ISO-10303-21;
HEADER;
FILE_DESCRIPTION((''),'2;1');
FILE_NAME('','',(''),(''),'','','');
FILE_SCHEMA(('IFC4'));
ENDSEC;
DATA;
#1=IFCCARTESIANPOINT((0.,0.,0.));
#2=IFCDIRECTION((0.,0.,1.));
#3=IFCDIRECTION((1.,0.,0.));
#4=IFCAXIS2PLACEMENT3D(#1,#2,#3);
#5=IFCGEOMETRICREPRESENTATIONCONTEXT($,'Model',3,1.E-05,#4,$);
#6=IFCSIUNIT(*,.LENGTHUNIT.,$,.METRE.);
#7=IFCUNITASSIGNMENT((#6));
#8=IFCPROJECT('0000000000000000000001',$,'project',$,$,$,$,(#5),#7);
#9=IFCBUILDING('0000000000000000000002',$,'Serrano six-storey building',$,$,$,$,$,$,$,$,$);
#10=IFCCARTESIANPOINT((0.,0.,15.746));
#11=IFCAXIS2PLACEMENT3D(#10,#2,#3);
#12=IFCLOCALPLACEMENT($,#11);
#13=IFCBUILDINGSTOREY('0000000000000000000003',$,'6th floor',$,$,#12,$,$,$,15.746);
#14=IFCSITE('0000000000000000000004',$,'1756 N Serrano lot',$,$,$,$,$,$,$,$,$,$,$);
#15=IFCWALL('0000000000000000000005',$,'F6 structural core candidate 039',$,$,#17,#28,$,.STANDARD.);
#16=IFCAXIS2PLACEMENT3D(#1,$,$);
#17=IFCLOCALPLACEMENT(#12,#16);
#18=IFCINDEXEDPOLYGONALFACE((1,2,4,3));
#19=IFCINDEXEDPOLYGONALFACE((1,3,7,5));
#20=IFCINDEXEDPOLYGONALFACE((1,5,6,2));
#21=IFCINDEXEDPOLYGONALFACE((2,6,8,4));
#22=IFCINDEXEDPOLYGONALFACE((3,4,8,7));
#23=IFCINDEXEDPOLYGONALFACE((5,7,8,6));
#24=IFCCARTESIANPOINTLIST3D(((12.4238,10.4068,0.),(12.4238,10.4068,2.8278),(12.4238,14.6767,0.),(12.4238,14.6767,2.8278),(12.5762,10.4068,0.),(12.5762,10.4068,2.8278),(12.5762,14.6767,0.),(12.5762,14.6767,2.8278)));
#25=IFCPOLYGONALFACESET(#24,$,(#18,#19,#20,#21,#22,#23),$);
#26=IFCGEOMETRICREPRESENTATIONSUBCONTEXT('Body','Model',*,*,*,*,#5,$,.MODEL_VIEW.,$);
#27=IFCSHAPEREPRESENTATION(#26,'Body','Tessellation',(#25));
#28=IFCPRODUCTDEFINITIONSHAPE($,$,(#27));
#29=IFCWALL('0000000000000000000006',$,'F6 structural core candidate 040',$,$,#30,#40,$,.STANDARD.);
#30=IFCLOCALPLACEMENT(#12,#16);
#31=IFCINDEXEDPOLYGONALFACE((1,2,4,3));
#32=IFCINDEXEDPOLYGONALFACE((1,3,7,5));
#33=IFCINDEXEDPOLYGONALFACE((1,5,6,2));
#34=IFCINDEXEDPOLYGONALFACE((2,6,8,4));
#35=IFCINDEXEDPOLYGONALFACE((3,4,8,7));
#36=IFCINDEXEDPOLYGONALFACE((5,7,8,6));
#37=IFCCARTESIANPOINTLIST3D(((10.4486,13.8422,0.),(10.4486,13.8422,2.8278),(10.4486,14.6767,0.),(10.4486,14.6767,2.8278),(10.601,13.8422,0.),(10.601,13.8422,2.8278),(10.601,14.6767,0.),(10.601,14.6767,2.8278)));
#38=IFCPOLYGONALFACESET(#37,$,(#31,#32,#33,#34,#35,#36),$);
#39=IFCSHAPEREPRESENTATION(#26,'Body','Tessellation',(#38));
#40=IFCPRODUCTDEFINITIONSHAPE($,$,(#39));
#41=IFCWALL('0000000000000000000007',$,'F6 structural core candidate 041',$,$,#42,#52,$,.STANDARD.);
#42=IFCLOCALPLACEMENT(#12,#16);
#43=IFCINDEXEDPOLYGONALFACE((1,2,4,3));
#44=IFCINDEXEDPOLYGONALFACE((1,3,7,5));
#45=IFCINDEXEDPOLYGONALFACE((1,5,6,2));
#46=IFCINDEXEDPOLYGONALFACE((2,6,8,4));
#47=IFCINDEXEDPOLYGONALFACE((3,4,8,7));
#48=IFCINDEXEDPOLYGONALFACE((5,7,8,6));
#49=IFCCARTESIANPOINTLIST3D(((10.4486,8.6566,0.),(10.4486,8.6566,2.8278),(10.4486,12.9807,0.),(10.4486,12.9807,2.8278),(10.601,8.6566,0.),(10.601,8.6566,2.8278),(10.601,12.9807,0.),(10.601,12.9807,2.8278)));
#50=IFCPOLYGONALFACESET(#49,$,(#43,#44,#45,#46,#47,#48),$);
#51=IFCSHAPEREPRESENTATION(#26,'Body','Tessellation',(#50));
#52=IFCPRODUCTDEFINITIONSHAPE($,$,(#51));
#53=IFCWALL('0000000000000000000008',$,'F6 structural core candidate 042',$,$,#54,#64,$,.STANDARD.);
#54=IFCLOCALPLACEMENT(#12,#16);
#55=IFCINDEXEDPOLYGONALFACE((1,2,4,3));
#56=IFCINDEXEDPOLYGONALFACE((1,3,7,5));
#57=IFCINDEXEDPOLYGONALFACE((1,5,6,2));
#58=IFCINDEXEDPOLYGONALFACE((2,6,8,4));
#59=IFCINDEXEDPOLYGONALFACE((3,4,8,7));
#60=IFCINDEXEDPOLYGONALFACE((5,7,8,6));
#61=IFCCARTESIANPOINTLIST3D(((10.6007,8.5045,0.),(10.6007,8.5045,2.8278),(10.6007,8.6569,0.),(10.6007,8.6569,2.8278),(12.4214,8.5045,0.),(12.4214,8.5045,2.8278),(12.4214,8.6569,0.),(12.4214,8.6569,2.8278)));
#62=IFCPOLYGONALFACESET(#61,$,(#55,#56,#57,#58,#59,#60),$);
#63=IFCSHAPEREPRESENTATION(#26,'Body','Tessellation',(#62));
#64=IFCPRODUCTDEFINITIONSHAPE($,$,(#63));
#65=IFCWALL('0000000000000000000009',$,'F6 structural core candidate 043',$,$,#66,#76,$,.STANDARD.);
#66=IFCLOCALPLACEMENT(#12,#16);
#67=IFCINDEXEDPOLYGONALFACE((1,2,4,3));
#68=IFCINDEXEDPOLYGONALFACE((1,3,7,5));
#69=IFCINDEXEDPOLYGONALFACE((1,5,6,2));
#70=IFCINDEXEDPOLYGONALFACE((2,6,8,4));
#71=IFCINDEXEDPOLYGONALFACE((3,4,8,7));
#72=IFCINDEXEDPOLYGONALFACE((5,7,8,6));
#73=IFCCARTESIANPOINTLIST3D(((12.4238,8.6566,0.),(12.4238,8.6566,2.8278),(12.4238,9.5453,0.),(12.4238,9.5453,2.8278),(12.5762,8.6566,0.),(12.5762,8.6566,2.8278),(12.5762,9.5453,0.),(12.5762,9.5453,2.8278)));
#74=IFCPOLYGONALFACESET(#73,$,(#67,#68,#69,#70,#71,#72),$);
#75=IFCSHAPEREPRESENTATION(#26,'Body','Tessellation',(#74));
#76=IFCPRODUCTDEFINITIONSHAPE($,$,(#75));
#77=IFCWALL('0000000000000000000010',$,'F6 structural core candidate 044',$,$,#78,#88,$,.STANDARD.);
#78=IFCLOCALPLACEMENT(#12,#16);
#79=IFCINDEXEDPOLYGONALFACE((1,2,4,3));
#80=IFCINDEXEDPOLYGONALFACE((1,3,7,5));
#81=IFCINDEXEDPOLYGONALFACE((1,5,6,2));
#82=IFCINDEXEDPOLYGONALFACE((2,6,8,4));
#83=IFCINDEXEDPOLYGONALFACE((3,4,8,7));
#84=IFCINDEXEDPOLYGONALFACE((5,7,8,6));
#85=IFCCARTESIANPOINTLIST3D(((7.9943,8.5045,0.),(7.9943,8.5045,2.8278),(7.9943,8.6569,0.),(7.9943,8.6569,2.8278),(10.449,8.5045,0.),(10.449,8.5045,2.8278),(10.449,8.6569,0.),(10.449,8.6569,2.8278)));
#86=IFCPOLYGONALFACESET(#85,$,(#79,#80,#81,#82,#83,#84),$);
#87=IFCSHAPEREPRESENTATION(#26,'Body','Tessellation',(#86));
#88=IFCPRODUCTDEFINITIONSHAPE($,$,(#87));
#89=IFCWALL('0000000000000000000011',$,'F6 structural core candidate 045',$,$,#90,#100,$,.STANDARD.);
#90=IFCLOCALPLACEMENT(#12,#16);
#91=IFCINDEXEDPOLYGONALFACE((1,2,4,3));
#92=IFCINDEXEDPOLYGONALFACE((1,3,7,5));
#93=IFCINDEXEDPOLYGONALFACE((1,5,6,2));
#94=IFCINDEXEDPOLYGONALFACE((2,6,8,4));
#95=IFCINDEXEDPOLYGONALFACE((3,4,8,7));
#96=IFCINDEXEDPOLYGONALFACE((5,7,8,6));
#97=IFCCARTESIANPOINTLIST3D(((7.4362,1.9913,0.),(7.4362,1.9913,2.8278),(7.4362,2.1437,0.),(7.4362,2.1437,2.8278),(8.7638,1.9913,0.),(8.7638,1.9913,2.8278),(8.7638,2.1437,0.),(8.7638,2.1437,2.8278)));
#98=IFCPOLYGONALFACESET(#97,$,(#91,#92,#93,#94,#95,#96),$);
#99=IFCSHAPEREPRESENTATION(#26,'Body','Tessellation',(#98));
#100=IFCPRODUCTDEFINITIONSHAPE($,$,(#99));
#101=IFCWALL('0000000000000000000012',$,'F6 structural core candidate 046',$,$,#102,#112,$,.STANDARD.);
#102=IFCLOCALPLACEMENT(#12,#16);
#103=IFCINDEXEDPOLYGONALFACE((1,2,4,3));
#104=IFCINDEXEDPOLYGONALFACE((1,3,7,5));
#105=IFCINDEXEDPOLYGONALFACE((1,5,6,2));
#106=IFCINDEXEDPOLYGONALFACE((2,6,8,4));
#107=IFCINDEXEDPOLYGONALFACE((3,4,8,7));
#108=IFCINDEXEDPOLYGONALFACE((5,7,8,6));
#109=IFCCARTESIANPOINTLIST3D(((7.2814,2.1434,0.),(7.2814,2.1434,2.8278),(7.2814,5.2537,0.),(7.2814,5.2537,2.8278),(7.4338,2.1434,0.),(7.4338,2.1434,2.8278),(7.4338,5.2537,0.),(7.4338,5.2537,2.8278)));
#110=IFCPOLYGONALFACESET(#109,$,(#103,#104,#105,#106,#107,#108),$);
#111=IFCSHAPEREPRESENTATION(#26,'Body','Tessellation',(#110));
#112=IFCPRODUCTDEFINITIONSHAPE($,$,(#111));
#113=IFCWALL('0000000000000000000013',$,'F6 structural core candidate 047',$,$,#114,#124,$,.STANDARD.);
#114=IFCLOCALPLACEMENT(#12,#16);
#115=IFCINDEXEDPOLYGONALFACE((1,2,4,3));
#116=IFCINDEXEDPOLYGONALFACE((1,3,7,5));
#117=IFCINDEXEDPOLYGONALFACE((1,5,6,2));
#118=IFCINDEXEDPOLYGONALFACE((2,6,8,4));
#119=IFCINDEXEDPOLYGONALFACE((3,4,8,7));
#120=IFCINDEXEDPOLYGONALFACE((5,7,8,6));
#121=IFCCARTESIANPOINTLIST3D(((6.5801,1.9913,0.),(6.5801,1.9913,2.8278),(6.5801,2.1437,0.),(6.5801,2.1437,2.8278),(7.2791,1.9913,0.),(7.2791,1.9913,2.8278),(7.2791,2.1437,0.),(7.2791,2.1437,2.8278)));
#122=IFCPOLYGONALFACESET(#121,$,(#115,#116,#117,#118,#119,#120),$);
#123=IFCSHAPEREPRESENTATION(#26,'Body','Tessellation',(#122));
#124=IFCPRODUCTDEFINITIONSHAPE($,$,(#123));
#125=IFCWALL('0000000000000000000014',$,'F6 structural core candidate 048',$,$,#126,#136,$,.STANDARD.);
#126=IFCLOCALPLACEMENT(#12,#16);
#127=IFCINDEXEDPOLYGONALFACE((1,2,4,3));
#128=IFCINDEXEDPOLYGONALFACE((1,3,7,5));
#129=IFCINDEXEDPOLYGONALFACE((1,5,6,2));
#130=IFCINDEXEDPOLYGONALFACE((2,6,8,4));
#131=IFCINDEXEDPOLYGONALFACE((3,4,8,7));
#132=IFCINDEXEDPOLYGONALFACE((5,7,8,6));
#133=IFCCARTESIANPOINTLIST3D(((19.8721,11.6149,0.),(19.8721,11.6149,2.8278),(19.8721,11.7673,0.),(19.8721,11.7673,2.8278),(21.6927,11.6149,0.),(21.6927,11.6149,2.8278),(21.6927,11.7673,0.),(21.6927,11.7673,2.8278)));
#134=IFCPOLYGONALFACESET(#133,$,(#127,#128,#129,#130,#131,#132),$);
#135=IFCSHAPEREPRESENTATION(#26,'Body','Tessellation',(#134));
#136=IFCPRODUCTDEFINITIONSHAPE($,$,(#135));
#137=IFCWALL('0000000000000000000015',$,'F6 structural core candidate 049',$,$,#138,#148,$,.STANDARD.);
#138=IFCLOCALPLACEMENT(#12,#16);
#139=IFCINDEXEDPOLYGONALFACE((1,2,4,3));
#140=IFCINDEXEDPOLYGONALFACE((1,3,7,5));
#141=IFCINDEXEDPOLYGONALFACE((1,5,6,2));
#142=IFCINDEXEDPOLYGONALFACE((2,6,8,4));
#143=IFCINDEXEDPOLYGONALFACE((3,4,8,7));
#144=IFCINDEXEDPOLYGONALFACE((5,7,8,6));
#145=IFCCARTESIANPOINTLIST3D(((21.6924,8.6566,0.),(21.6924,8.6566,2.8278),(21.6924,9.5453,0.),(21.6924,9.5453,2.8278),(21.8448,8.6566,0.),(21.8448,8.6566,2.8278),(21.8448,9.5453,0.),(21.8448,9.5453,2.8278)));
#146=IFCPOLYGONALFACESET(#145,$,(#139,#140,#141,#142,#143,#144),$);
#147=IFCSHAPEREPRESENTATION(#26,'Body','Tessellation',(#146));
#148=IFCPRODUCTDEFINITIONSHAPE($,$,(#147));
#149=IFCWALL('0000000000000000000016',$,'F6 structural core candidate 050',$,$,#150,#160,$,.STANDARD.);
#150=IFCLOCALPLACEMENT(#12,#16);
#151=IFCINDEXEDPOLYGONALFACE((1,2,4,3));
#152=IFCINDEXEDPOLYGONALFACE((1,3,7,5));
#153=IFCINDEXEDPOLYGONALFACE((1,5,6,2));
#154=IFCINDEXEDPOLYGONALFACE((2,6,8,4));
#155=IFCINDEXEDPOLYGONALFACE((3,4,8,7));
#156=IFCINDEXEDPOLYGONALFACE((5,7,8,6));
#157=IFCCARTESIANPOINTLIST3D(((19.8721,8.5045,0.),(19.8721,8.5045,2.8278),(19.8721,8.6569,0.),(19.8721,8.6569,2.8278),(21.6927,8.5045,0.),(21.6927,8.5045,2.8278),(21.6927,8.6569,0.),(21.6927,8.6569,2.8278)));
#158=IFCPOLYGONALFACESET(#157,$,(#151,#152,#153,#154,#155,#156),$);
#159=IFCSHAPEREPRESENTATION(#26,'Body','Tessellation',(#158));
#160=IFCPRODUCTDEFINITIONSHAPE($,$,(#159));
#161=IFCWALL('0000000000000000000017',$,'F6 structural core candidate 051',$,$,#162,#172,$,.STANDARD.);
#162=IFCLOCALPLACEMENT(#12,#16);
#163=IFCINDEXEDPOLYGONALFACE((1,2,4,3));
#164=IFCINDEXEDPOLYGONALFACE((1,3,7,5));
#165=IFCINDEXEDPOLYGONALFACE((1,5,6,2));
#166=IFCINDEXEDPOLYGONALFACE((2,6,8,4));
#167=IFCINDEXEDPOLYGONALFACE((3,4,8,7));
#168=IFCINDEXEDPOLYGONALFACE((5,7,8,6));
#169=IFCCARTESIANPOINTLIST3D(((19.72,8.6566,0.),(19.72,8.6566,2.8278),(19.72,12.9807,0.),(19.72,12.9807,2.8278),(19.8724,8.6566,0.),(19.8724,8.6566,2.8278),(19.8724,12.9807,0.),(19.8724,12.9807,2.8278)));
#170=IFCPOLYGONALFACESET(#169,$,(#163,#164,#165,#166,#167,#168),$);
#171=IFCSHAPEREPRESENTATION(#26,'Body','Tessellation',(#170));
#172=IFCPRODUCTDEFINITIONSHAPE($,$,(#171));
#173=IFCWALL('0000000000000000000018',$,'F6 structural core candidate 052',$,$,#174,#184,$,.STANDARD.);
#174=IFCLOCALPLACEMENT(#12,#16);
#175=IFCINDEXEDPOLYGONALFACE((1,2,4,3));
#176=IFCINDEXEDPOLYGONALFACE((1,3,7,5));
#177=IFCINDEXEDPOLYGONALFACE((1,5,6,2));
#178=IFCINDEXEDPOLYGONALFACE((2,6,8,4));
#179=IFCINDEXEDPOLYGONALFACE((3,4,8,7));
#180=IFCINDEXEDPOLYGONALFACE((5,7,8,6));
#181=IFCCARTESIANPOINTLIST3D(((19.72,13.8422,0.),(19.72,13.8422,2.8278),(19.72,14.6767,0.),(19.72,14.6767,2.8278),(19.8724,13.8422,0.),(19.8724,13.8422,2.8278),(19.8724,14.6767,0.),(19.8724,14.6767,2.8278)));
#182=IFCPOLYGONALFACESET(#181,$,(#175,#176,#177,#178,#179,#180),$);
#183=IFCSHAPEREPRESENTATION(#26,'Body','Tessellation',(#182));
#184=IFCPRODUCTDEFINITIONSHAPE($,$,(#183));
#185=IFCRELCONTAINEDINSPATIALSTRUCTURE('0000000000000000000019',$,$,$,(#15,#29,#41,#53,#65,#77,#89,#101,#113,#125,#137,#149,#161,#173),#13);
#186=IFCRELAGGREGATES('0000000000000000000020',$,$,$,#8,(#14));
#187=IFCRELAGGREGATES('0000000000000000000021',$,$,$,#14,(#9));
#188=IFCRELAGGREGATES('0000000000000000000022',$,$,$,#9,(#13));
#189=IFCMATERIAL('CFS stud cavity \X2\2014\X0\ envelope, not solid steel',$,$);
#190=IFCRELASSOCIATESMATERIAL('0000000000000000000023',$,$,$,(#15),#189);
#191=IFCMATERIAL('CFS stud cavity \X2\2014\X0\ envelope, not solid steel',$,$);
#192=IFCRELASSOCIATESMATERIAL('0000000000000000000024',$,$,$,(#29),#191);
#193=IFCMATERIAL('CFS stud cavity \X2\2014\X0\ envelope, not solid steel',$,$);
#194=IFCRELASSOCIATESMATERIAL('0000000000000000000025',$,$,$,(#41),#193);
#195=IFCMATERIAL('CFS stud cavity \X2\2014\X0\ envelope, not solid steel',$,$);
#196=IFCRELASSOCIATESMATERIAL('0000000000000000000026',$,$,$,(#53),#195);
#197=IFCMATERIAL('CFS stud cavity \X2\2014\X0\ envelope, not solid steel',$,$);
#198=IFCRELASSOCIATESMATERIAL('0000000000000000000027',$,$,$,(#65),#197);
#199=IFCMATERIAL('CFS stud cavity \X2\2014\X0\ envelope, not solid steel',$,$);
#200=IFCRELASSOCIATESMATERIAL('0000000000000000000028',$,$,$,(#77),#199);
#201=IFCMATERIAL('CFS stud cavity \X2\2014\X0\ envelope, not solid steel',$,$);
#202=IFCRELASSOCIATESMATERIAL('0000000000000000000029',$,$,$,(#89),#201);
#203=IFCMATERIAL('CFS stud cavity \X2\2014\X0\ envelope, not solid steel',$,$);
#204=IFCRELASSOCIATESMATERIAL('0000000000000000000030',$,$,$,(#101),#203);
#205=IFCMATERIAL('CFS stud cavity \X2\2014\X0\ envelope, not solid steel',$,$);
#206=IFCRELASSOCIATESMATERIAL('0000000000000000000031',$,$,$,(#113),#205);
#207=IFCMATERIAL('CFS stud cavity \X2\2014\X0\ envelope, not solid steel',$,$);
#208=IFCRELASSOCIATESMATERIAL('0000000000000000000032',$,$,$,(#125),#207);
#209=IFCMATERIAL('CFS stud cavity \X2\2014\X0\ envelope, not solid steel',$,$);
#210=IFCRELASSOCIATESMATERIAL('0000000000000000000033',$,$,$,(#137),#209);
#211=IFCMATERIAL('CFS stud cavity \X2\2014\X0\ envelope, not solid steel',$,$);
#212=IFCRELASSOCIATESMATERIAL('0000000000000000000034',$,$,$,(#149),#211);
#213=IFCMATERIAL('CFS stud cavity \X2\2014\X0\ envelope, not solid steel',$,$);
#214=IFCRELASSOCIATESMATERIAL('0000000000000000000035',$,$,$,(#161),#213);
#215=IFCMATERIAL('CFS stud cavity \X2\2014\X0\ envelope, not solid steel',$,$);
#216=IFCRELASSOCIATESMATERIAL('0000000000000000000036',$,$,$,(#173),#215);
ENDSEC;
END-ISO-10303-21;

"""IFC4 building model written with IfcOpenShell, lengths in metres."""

from ifc_helpers import new_model, si_unit, frame, origin_with_axes, place, context, subcontext, project, spatial, polyline, outline, extrude, material, element, save


model = new_model("IFC4")

# Units and contexts
model_context = context("Model", 3, precision=1e-05, world=origin_with_axes())
body_context = subcontext(model_context, "Body", "Model", "MODEL_VIEW")
ifc_project = project(units=[si_unit("LENGTHUNIT", "METRE")], contexts=[model_context])

# Site, building, storey
site = spatial("IfcSite", under=ifc_project, Name="1756 N Serrano lot")
building = spatial("IfcBuilding", under=site, Name="Serrano six-storey building")
storey_placement = place(None, frame((0.0, 0.0, 15.746), z_axis=(0.0, 0.0, 1.0), x_axis=(1.0, 0.0, 0.0)))
storey = spatial("IfcBuildingStorey", under=building, at=storey_placement, Name="6th floor", Elevation=15.746)

# Walls
ifc_material_1 = material(Name="CFS stud cavity — envelope, not solid steel")
wall_1_placement = place(storey_placement, frame((0.0, 0.0, -15.746), z_axis=(0.0, 0.0, 1.0), x_axis=(1.0, 0.0, 0.0)))
element("IfcWall", 1, at=wall_1_placement, inside=storey, material=ifc_material_1, Name="F6 structural core candidate 039", PredefinedType="STANDARD", context=body_context, shape_type="SweptSolid", body=[
    extrude(outline(polyline([(12.5762, 10.4068), (12.4238, 10.4068), (12.4238, 14.6767), (12.5762, 14.6767), (12.5762, 10.4068)])), frame((0.0, 0.0, 15.746)), (0.0, 0.0, 1.0), 2.8278),
])
ifc_material_2 = material(Name="CFS stud cavity — envelope, not solid steel")
wall_2_placement = place(storey_placement, frame((0.0, 0.0, -15.746), z_axis=(0.0, 0.0, 1.0), x_axis=(1.0, 0.0, 0.0)))
element("IfcWall", 2, at=wall_2_placement, inside=storey, material=ifc_material_2, Name="F6 structural core candidate 040", PredefinedType="STANDARD", context=body_context, shape_type="SweptSolid", body=[
    extrude(outline(polyline([(10.601, 13.8422), (10.4486, 13.8422), (10.4486, 14.6767), (10.601, 14.6767), (10.601, 13.8422)])), frame((0.0, 0.0, 15.746)), (0.0, 0.0, 1.0), 2.8278),
])
ifc_material_3 = material(Name="CFS stud cavity — envelope, not solid steel")
wall_3_placement = place(storey_placement, frame((0.0, 0.0, -15.746), z_axis=(0.0, 0.0, 1.0), x_axis=(1.0, 0.0, 0.0)))
element("IfcWall", 3, at=wall_3_placement, inside=storey, material=ifc_material_3, Name="F6 structural core candidate 041", PredefinedType="STANDARD", context=body_context, shape_type="SweptSolid", body=[
    extrude(outline(polyline([(10.601, 8.6566), (10.4486, 8.6566), (10.4486, 12.9807), (10.601, 12.9807), (10.601, 8.6566)])), frame((0.0, 0.0, 15.746)), (0.0, 0.0, 1.0), 2.8278),
])
ifc_material_4 = material(Name="CFS stud cavity — envelope, not solid steel")
wall_4_placement = place(storey_placement, frame((0.0, 0.0, -15.746), z_axis=(0.0, 0.0, 1.0), x_axis=(1.0, 0.0, 0.0)))
element("IfcWall", 4, at=wall_4_placement, inside=storey, material=ifc_material_4, Name="F6 structural core candidate 042", PredefinedType="STANDARD", context=body_context, shape_type="SweptSolid", body=[
    extrude(outline(polyline([(12.4214, 8.6569), (12.4214, 8.5045), (10.6007, 8.5045), (10.6007, 8.6569), (12.4214, 8.6569)])), frame((0.0, 0.0, 15.746)), (0.0, 0.0, 1.0), 2.8278),
])
ifc_material_5 = material(Name="CFS stud cavity — envelope, not solid steel")
wall_5_placement = place(storey_placement, frame((0.0, 0.0, -15.746), z_axis=(0.0, 0.0, 1.0), x_axis=(1.0, 0.0, 0.0)))
element("IfcWall", 5, at=wall_5_placement, inside=storey, material=ifc_material_5, Name="F6 structural core candidate 043", PredefinedType="STANDARD", context=body_context, shape_type="SweptSolid", body=[
    extrude(outline(polyline([(12.5762, 8.6566), (12.4238, 8.6566), (12.4238, 9.5453), (12.5762, 9.5453), (12.5762, 8.6566)])), frame((0.0, 0.0, 15.746)), (0.0, 0.0, 1.0), 2.8278),
])
ifc_material_6 = material(Name="CFS stud cavity — envelope, not solid steel")
wall_6_placement = place(storey_placement, frame((0.0, 0.0, -15.746), z_axis=(0.0, 0.0, 1.0), x_axis=(1.0, 0.0, 0.0)))
element("IfcWall", 6, at=wall_6_placement, inside=storey, material=ifc_material_6, Name="F6 structural core candidate 044", PredefinedType="STANDARD", context=body_context, shape_type="SweptSolid", body=[
    extrude(outline(polyline([(10.449, 8.6569), (10.449, 8.5045), (7.9943, 8.5045), (7.9943, 8.6569), (10.449, 8.6569)])), frame((0.0, 0.0, 15.746)), (0.0, 0.0, 1.0), 2.8278),
])
ifc_material_7 = material(Name="CFS stud cavity — envelope, not solid steel")
wall_7_placement = place(storey_placement, frame((0.0, 0.0, -15.746), z_axis=(0.0, 0.0, 1.0), x_axis=(1.0, 0.0, 0.0)))
element("IfcWall", 7, at=wall_7_placement, inside=storey, material=ifc_material_7, Name="F6 structural core candidate 045", PredefinedType="STANDARD", context=body_context, shape_type="SweptSolid", body=[
    extrude(outline(polyline([(8.7638, 2.1437), (8.7638, 1.9913), (7.4362, 1.9913), (7.4362, 2.1437), (8.7638, 2.1437)])), frame((0.0, 0.0, 15.746)), (0.0, 0.0, 1.0), 2.8278),
])
ifc_material_8 = material(Name="CFS stud cavity — envelope, not solid steel")
wall_8_placement = place(storey_placement, frame((0.0, 0.0, -15.746), z_axis=(0.0, 0.0, 1.0), x_axis=(1.0, 0.0, 0.0)))
element("IfcWall", 8, at=wall_8_placement, inside=storey, material=ifc_material_8, Name="F6 structural core candidate 046", PredefinedType="STANDARD", context=body_context, shape_type="SweptSolid", body=[
    extrude(outline(polyline([(7.4338, 2.1434), (7.2814, 2.1434), (7.2814, 5.2537), (7.4338, 5.2537), (7.4338, 2.1434)])), frame((0.0, 0.0, 15.746)), (0.0, 0.0, 1.0), 2.8278),
])
ifc_material_9 = material(Name="CFS stud cavity — envelope, not solid steel")
wall_9_placement = place(storey_placement, frame((0.0, 0.0, -15.746), z_axis=(0.0, 0.0, 1.0), x_axis=(1.0, 0.0, 0.0)))
element("IfcWall", 9, at=wall_9_placement, inside=storey, material=ifc_material_9, Name="F6 structural core candidate 047", PredefinedType="STANDARD", context=body_context, shape_type="SweptSolid", body=[
    extrude(outline(polyline([(7.2791, 2.1437), (7.2791, 1.9913), (6.5801, 1.9913), (6.5801, 2.1437), (7.2791, 2.1437)])), frame((0.0, 0.0, 15.746)), (0.0, 0.0, 1.0), 2.8278),
])
ifc_material_10 = material(Name="CFS stud cavity — envelope, not solid steel")
wall_10_placement = place(storey_placement, frame((0.0, 0.0, -15.746), z_axis=(0.0, 0.0, 1.0), x_axis=(1.0, 0.0, 0.0)))
element("IfcWall", 10, at=wall_10_placement, inside=storey, material=ifc_material_10, Name="F6 structural core candidate 048", PredefinedType="STANDARD", context=body_context, shape_type="SweptSolid", body=[
    extrude(outline(polyline([(21.6927, 11.7673), (21.6927, 11.6149), (19.8721, 11.6149), (19.8721, 11.7673), (21.6927, 11.7673)])), frame((0.0, 0.0, 15.746)), (0.0, 0.0, 1.0), 2.8278),
])
ifc_material_11 = material(Name="CFS stud cavity — envelope, not solid steel")
wall_11_placement = place(storey_placement, frame((0.0, 0.0, -15.746), z_axis=(0.0, 0.0, 1.0), x_axis=(1.0, 0.0, 0.0)))
element("IfcWall", 11, at=wall_11_placement, inside=storey, material=ifc_material_11, Name="F6 structural core candidate 049", PredefinedType="STANDARD", context=body_context, shape_type="SweptSolid", body=[
    extrude(outline(polyline([(21.8448, 8.6566), (21.6924, 8.6566), (21.6924, 9.5453), (21.8448, 9.5453), (21.8448, 8.6566)])), frame((0.0, 0.0, 15.746)), (0.0, 0.0, 1.0), 2.8278),
])
ifc_material_12 = material(Name="CFS stud cavity — envelope, not solid steel")
wall_12_placement = place(storey_placement, frame((0.0, 0.0, -15.746), z_axis=(0.0, 0.0, 1.0), x_axis=(1.0, 0.0, 0.0)))
element("IfcWall", 12, at=wall_12_placement, inside=storey, material=ifc_material_12, Name="F6 structural core candidate 050", PredefinedType="STANDARD", context=body_context, shape_type="SweptSolid", body=[
    extrude(outline(polyline([(21.6927, 8.6569), (21.6927, 8.5045), (19.8721, 8.5045), (19.8721, 8.6569), (21.6927, 8.6569)])), frame((0.0, 0.0, 15.746)), (0.0, 0.0, 1.0), 2.8278),
])
ifc_material_13 = material(Name="CFS stud cavity — envelope, not solid steel")
wall_13_placement = place(storey_placement, frame((0.0, 0.0, -15.746), z_axis=(0.0, 0.0, 1.0), x_axis=(1.0, 0.0, 0.0)))
element("IfcWall", 13, at=wall_13_placement, inside=storey, material=ifc_material_13, Name="F6 structural core candidate 051", PredefinedType="STANDARD", context=body_context, shape_type="SweptSolid", body=[
    extrude(outline(polyline([(19.8724, 8.6566), (19.72, 8.6566), (19.72, 12.9807), (19.8724, 12.9807), (19.8724, 8.6566)])), frame((0.0, 0.0, 15.746)), (0.0, 0.0, 1.0), 2.8278),
])
ifc_material_14 = material(Name="CFS stud cavity — envelope, not solid steel")
wall_14_placement = place(storey_placement, frame((0.0, 0.0, -15.746), z_axis=(0.0, 0.0, 1.0), x_axis=(1.0, 0.0, 0.0)))
element("IfcWall", 14, at=wall_14_placement, inside=storey, material=ifc_material_14, Name="F6 structural core candidate 052", PredefinedType="STANDARD", context=body_context, shape_type="SweptSolid", body=[
    extrude(outline(polyline([(19.8724, 13.8422), (19.72, 13.8422), (19.72, 14.6767), (19.8724, 14.6767), (19.8724, 13.8422)])), frame((0.0, 0.0, 15.746)), (0.0, 0.0, 1.0), 2.8278),
])

save(model, "model.ifc")
